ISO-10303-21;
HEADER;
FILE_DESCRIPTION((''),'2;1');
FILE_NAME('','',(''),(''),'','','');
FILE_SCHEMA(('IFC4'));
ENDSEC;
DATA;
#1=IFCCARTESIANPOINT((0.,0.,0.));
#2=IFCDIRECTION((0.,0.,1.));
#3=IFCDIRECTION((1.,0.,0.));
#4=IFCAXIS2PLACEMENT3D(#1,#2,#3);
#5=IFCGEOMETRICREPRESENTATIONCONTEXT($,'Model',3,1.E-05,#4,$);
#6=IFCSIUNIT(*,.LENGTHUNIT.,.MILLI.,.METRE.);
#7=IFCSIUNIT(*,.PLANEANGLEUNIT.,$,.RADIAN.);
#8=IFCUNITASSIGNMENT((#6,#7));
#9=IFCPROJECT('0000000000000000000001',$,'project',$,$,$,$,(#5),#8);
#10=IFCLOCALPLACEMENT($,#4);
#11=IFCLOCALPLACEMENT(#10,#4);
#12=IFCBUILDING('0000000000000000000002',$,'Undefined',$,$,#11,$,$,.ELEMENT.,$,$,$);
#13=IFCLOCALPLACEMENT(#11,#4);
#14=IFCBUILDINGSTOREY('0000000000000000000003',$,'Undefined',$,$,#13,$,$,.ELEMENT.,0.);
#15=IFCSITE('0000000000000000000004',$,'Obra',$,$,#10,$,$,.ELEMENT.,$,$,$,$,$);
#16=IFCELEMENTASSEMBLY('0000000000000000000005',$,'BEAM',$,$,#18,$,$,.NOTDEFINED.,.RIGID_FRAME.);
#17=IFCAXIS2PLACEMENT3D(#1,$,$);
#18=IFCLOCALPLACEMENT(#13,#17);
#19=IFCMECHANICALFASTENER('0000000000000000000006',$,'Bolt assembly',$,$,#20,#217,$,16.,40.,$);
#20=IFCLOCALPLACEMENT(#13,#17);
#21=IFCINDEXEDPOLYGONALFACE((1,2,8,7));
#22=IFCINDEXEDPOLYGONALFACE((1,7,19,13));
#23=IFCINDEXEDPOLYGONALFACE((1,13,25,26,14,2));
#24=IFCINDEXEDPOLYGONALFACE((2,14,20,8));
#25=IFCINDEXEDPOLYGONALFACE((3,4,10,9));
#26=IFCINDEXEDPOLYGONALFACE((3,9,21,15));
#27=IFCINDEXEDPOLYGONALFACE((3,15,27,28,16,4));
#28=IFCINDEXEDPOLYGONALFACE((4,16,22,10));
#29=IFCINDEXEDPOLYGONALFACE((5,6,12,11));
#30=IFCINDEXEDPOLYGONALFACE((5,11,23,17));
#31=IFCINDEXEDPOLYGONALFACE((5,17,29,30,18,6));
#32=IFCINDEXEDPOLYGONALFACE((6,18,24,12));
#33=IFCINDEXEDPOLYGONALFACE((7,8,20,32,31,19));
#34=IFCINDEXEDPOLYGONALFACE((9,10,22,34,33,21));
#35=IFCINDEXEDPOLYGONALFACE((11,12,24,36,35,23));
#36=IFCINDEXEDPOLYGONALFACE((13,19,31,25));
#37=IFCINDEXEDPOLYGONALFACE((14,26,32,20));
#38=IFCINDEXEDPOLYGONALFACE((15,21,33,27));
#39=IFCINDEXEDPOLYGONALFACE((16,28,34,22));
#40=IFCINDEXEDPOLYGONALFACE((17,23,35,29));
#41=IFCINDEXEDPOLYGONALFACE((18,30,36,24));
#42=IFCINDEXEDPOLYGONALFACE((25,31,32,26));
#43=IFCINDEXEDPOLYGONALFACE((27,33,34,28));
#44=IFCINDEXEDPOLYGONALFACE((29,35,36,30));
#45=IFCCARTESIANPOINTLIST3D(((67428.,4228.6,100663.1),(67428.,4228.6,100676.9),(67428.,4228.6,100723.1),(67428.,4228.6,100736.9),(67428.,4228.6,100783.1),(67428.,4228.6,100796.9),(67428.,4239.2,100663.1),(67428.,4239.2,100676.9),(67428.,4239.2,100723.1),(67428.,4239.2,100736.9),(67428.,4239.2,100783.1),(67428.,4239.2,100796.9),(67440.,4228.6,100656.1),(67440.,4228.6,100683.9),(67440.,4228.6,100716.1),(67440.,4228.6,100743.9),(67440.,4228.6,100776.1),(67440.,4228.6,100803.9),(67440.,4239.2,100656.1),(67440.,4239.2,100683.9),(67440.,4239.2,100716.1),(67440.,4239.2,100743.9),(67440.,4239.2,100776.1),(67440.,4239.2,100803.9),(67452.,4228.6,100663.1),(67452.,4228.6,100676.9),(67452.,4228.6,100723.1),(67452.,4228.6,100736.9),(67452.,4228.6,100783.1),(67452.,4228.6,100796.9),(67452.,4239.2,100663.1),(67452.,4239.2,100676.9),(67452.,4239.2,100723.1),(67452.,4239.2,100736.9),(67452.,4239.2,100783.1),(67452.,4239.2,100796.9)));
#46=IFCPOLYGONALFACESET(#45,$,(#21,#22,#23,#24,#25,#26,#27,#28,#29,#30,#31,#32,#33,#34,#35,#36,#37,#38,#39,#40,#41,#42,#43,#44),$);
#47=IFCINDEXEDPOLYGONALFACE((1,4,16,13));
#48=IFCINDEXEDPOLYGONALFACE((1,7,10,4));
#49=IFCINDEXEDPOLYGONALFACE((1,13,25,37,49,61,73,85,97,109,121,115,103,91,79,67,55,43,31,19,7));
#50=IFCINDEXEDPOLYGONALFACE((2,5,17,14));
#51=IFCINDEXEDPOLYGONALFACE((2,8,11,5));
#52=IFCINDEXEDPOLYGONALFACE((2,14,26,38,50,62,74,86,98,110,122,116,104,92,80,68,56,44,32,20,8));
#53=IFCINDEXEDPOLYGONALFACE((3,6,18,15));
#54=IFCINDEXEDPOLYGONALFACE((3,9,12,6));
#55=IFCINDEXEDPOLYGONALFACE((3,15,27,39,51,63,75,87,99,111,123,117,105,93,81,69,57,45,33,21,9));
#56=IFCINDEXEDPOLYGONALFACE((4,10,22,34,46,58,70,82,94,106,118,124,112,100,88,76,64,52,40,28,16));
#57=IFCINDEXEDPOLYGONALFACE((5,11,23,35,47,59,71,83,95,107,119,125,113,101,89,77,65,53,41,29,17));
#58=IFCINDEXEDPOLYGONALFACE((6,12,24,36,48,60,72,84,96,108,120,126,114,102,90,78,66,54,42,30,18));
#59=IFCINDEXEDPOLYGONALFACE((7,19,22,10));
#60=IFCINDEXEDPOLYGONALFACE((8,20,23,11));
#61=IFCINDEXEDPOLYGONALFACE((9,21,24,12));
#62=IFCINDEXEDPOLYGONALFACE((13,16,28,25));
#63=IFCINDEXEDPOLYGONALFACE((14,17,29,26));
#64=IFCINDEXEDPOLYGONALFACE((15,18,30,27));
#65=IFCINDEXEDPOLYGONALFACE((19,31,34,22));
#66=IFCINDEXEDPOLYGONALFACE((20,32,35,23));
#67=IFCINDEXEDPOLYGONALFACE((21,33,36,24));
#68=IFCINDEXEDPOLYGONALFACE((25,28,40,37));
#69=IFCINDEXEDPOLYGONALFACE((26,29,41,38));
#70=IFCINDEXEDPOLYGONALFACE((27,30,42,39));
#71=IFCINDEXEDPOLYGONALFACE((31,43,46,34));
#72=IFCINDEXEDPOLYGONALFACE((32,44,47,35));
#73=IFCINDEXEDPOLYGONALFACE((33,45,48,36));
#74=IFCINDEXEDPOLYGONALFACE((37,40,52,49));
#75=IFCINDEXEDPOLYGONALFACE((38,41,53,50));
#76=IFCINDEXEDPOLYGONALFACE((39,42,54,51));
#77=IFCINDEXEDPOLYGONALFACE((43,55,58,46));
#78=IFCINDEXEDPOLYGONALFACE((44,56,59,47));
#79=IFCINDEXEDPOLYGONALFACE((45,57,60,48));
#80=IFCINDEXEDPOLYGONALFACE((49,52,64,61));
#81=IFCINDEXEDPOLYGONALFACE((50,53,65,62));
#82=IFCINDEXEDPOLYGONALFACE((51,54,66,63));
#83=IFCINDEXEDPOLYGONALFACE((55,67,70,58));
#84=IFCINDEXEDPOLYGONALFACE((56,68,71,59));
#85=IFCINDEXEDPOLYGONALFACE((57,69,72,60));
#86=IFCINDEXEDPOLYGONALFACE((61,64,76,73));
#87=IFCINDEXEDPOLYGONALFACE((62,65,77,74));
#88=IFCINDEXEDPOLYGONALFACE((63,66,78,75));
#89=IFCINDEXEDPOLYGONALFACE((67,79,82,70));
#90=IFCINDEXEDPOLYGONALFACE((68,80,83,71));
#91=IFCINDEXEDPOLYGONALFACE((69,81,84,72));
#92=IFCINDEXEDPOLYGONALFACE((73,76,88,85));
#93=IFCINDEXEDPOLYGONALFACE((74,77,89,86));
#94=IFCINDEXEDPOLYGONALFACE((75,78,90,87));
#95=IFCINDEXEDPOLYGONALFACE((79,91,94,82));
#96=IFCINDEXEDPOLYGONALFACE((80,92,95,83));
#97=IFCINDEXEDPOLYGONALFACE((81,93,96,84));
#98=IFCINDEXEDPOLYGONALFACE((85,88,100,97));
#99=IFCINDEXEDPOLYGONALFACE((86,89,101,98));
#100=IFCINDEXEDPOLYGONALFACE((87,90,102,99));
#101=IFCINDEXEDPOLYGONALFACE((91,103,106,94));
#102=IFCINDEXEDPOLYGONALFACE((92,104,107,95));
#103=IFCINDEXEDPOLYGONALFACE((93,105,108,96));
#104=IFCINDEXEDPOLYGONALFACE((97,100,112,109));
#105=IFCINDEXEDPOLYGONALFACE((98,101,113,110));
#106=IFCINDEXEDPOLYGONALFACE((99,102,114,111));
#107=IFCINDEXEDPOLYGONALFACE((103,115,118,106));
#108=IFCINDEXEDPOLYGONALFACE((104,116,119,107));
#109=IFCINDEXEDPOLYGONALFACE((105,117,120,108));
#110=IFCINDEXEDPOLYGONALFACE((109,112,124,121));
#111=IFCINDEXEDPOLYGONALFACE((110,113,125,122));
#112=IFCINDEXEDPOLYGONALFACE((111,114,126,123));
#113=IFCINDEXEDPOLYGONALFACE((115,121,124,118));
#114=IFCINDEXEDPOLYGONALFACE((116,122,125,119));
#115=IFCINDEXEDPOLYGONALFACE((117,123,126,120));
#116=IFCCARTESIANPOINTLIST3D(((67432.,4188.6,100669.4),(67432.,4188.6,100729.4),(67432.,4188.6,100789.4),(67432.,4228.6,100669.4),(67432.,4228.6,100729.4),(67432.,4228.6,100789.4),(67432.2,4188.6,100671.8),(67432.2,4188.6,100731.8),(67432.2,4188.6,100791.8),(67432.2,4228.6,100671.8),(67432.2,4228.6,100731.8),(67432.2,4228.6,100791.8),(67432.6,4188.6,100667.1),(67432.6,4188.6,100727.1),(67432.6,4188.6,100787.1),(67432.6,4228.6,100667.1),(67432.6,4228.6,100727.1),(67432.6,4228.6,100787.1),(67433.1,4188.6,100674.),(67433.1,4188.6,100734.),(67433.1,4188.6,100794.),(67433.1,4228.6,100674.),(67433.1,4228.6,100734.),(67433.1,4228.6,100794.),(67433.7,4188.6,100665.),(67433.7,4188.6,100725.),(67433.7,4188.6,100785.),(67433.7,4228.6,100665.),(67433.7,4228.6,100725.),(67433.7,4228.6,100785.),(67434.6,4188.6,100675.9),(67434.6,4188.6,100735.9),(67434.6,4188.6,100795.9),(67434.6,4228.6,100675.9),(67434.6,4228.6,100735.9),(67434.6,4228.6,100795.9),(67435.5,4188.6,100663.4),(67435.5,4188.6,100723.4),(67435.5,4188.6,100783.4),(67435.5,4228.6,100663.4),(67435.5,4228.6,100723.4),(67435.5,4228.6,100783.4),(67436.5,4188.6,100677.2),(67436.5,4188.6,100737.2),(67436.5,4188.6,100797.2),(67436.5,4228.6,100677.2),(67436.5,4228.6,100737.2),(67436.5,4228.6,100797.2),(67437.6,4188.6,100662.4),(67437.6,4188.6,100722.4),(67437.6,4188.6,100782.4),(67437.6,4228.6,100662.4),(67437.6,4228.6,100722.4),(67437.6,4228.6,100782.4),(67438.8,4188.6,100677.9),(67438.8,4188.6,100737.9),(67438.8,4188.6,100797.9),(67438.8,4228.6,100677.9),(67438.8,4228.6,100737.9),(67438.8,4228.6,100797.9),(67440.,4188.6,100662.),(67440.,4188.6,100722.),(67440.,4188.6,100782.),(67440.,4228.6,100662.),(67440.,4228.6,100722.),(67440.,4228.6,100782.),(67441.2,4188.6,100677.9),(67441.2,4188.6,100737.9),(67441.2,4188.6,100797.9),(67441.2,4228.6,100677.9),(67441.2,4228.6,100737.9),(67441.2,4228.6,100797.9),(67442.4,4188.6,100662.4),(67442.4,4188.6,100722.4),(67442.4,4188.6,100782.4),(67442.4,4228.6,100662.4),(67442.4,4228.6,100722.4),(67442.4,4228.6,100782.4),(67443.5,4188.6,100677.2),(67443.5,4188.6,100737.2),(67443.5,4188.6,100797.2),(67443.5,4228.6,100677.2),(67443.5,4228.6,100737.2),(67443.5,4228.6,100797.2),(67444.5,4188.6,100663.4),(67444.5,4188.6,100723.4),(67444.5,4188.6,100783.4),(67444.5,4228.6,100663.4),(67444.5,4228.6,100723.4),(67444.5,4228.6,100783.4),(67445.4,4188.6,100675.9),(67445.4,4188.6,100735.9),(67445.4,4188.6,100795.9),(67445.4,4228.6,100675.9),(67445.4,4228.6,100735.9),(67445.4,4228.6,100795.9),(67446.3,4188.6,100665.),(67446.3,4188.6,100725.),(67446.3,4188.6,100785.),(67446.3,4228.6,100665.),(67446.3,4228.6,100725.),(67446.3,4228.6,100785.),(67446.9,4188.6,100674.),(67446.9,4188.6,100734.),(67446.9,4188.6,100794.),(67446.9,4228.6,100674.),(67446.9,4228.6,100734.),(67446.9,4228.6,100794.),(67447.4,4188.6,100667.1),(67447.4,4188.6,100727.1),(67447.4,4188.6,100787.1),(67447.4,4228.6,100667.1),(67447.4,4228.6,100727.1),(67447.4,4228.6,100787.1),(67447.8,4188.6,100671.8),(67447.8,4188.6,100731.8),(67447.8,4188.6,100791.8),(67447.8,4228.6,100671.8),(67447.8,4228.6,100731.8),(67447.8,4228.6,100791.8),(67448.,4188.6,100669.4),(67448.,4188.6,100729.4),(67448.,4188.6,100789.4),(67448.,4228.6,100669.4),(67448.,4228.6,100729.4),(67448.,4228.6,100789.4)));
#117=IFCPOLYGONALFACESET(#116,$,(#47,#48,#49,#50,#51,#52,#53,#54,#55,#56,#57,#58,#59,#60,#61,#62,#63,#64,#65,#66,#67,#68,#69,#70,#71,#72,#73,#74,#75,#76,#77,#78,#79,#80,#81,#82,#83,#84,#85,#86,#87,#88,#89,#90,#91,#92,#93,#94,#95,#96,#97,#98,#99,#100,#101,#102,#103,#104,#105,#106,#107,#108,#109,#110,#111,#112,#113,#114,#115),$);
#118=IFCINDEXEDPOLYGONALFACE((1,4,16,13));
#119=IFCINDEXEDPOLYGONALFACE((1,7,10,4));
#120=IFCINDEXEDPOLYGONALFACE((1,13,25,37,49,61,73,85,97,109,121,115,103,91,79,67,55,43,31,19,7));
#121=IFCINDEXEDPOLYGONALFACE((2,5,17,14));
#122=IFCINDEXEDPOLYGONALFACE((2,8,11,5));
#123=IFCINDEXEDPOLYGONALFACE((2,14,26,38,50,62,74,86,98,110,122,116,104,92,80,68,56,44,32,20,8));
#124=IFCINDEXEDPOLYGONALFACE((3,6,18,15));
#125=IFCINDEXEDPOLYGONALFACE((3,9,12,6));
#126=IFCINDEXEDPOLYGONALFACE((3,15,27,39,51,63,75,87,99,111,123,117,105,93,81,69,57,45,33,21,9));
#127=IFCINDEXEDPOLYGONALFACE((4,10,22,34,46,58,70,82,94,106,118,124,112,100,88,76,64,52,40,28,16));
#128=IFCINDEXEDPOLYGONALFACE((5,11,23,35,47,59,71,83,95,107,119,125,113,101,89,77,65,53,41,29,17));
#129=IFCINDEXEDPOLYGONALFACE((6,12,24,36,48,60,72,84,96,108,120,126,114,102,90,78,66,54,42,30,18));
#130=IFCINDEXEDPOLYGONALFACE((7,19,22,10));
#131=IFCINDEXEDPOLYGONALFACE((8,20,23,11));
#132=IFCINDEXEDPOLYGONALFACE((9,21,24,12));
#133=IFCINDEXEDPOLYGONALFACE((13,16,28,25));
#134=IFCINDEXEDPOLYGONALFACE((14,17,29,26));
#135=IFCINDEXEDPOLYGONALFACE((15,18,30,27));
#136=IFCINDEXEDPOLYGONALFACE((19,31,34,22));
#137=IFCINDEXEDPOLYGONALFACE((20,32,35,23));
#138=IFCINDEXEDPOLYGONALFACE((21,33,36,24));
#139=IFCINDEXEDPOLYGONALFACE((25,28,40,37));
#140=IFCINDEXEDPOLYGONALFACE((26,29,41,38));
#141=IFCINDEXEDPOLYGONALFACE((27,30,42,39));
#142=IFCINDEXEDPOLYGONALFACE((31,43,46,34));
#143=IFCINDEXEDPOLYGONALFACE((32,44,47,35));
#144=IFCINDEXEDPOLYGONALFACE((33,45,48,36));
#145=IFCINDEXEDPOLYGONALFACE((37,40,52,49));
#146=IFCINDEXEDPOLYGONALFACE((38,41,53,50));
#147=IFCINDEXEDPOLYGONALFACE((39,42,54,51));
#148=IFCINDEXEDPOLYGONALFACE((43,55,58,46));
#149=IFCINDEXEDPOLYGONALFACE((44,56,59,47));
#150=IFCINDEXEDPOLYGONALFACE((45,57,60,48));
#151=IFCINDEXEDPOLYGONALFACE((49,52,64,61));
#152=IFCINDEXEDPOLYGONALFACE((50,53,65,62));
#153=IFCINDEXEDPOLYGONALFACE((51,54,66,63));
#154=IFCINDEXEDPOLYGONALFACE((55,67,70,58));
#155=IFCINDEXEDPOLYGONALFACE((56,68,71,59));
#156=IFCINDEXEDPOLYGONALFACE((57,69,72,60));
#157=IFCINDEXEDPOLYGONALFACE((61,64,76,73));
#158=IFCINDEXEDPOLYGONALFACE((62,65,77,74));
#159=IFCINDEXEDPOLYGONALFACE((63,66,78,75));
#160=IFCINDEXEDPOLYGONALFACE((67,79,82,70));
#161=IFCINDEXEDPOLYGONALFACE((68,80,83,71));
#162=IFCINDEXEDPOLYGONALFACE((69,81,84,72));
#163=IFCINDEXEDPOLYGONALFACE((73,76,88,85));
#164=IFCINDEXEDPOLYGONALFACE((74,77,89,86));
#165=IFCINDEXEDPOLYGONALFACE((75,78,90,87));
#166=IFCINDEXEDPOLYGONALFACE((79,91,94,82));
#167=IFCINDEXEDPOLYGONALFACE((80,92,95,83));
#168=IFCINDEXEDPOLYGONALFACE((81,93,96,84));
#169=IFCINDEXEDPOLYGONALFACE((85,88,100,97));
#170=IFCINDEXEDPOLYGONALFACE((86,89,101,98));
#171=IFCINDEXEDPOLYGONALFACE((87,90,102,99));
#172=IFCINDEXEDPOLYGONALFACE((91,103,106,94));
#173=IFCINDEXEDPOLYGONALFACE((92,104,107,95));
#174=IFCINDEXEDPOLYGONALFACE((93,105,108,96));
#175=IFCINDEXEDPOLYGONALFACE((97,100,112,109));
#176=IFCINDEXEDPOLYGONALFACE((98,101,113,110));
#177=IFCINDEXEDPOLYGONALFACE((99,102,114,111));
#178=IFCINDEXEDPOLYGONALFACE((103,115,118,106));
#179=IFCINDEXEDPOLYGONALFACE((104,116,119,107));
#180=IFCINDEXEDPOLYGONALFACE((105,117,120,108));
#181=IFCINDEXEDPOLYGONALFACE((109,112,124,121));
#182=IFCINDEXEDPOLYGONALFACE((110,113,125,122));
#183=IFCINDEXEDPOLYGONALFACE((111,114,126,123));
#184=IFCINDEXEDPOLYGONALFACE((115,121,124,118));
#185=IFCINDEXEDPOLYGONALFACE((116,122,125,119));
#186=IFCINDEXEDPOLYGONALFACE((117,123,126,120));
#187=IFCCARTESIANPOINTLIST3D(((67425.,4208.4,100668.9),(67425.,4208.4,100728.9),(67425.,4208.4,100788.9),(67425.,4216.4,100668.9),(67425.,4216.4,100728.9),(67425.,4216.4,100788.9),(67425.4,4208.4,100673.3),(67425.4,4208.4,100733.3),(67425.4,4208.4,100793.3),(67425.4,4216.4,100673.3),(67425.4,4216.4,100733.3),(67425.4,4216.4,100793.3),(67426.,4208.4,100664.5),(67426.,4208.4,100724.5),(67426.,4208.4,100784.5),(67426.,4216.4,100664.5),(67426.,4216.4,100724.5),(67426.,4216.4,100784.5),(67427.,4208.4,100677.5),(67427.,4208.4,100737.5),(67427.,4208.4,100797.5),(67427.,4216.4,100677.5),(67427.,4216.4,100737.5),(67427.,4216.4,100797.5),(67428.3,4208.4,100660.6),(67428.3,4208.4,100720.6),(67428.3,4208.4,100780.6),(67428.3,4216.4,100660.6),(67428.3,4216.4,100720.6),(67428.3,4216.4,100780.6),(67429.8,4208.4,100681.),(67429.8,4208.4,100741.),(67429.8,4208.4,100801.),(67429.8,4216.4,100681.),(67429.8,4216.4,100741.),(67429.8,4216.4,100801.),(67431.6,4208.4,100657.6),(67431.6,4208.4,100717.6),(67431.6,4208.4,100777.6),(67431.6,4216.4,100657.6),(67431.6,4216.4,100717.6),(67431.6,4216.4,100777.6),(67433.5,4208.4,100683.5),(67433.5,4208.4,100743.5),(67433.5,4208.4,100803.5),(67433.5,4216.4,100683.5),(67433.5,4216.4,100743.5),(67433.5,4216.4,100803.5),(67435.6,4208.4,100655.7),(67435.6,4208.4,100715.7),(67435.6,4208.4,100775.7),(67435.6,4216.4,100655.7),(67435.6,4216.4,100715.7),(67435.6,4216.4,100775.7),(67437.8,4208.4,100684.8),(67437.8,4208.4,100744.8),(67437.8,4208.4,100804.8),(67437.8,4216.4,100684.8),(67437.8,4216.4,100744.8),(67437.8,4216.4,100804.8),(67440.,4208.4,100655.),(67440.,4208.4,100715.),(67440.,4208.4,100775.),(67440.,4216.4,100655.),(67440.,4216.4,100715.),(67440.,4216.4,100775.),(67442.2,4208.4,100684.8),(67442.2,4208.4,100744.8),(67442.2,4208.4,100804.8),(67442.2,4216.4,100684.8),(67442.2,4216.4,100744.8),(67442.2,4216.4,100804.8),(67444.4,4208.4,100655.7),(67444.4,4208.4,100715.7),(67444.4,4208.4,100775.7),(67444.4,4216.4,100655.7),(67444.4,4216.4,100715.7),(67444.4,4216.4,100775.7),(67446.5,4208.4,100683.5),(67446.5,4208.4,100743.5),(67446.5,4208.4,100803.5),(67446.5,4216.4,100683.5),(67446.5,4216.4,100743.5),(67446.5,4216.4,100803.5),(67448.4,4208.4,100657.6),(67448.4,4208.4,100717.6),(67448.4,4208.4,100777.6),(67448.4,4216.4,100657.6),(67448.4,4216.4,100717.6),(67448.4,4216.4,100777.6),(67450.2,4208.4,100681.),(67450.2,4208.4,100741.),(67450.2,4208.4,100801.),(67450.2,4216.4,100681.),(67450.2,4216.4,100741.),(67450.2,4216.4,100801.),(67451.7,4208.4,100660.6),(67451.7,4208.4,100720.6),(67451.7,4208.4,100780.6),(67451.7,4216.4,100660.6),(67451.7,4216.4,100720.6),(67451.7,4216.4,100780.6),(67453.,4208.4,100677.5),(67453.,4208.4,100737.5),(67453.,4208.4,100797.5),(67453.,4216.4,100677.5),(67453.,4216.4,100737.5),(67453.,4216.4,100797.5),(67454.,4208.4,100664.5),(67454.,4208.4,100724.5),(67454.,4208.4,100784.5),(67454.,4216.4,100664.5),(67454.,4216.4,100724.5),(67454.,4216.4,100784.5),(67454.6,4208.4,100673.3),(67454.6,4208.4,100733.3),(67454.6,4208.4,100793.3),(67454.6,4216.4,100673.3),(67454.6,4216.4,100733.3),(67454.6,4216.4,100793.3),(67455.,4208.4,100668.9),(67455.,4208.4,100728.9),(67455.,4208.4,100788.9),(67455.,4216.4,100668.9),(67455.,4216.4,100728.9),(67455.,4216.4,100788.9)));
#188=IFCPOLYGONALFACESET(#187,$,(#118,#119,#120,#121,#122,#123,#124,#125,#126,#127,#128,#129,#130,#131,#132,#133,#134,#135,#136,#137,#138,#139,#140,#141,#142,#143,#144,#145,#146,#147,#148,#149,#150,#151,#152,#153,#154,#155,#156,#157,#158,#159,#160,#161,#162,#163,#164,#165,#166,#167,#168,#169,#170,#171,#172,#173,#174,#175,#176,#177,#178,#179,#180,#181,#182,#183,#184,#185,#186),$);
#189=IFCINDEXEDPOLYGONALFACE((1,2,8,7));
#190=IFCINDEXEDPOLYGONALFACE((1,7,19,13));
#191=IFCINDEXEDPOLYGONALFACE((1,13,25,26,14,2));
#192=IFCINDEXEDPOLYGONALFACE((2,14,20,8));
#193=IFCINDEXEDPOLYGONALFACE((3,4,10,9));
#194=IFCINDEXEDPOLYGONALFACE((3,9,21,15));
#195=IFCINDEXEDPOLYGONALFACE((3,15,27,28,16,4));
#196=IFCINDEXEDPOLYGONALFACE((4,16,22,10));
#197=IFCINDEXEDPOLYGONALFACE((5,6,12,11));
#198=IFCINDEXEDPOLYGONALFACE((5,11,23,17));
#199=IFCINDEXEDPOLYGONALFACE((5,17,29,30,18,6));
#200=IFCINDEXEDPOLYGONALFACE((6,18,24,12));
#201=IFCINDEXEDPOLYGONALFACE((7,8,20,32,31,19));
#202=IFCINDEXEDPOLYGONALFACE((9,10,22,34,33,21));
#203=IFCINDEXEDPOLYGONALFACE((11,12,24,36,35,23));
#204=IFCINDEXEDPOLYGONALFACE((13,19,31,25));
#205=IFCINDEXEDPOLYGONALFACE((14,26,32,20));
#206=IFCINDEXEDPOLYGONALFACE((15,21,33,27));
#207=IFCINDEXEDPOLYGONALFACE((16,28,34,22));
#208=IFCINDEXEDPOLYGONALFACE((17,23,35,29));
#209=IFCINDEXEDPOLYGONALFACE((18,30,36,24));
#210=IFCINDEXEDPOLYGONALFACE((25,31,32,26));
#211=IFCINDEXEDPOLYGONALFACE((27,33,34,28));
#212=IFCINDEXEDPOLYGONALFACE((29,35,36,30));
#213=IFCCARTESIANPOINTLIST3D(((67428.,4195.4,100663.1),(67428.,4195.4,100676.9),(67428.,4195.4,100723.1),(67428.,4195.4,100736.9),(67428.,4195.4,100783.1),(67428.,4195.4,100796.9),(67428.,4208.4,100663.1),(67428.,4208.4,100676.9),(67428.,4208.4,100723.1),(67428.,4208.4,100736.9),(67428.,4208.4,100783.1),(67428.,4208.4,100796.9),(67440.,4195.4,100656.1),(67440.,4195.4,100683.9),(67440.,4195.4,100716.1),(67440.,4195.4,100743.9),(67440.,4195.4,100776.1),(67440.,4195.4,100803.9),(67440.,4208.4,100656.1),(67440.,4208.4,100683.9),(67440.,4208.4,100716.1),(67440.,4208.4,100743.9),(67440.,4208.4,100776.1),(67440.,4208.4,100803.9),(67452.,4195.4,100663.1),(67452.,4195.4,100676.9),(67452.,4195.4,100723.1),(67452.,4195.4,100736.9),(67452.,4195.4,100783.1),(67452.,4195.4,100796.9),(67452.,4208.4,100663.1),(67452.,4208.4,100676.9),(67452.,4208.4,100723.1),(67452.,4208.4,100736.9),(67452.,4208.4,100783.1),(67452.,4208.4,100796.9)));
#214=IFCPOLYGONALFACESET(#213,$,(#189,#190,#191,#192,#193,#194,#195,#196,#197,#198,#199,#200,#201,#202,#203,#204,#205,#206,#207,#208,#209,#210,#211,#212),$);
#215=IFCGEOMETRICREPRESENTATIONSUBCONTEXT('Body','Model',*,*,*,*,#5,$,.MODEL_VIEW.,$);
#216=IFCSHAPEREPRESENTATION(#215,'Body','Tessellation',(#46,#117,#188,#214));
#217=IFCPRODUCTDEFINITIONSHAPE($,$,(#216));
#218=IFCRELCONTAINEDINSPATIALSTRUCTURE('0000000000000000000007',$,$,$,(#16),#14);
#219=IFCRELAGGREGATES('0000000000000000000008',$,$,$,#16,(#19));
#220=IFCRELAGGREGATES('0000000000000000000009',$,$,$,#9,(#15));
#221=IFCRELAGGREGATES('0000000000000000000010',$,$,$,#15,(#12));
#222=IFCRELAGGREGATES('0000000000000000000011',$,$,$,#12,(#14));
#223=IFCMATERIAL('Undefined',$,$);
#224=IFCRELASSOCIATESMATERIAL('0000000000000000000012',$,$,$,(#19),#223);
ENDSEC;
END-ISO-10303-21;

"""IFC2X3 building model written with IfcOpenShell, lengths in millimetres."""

from ifc_helpers import new_model, si_unit, frame, origin_with_axes, origin_2d_with_axis, place, context, subcontext, project, spatial, polyline, circle, outline, extrude, source, transform, mapped, material, element, aggregate, save


model = new_model("IFC2X3")

# Units and contexts
model_context = context("Model", 3, precision=1e-05, world=origin_with_axes())
body_context = subcontext(model_context, "Body", "Model", "MODEL_VIEW")
ifc_project = project(units=[si_unit("LENGTHUNIT", "METRE", prefix="MILLI"), si_unit("PLANEANGLEUNIT", "RADIAN")], contexts=[model_context])

# Site, building, storey
site_placement = place(None, origin_with_axes())
site = spatial("IfcSite", under=ifc_project, at=site_placement, Name="Obra", CompositionType="ELEMENT")
building_placement = place(site_placement, origin_with_axes())
building = spatial("IfcBuilding", under=site, at=building_placement, Name="Undefined", CompositionType="ELEMENT")
storey_placement = place(building_placement, origin_with_axes())
storey = spatial("IfcBuildingStorey", under=building, at=storey_placement, Name="Undefined", CompositionType="ELEMENT", Elevation=0.0)

# Shared definitions
ifc_material_1 = material(Name="Undefined")

# Shared definitions
shared_shape_1 = source(origin_with_axes(), body_context, "Body", "SweptSolid", [
    extrude(outline(polyline([(13.9, 0.0), (6.9, 12.0), (-6.9, 12.0), (-13.9, 0.0), (-6.9, -12.0), (6.9, -12.0), (13.9, 0.0)])), frame((0.0, -19.7, 0.0), z_axis=(0.0, 1.0, 0.0), x_axis=(1.0, 0.0, 0.0)), (0.0, 0.0, 1.0), 10.6),
    extrude(circle(Radius=8.0, at=origin_2d_with_axis()), frame((0.0, -9.1, 0.0), z_axis=(0.0, 1.0, 0.0), x_axis=(1.0, 0.0, 0.0)), (0.0, 0.0, 1.0), 40.0),
    extrude(circle(Radius=15.0, at=origin_2d_with_axis()), frame((0.0, 3.1, 0.0), z_axis=(0.0, 1.0, 0.0), x_axis=(1.0, 0.0, 0.0)), (0.0, 0.0, 1.0), 8.0),
    extrude(outline(polyline([(13.9, 0.0), (6.9, 12.0), (-6.9, 12.0), (-13.9, 0.0), (-6.9, -12.0), (6.9, -12.0), (13.9, 0.0)])), frame((0.0, 11.1, 0.0), z_axis=(0.0, 1.0, 0.0), x_axis=(1.0, 0.0, 0.0)), (0.0, 0.0, 1.0), 13.0),
])

# Element assembly, mechanical fastener
assembly_1_placement = place(storey_placement, origin_with_axes())
assembly_1 = element("IfcElementAssembly", 1, at=assembly_1_placement, inside=storey, Name="BEAM", AssemblyPlace="NOTDEFINED", PredefinedType="RIGID_FRAME")
mechanical_fastener_1_placement = place(assembly_1_placement, frame((67490.0, 4219.5, 100850.0), z_axis=(-1.0, 0.0, 0.0), x_axis=(0.0, 0.0, -1.0)))
mechanical_fastener_1 = element("IfcMechanicalFastener", 2, at=mechanical_fastener_1_placement, material=ifc_material_1, Name="Bolt assembly", NominalDiameter=16.0, NominalLength=40.0, context=body_context, shape_type="MappedRepresentation", body=[
    mapped(shared_shape_1, transform((60.0, 0.0, 50.0))),
    mapped(shared_shape_1, transform((120.0, 0.0, 50.0))),
    mapped(shared_shape_1, transform((180.0, 0.0, 50.0))),
])
aggregate(assembly_1, [mechanical_fastener_1])

save(model, "model.ifc")
